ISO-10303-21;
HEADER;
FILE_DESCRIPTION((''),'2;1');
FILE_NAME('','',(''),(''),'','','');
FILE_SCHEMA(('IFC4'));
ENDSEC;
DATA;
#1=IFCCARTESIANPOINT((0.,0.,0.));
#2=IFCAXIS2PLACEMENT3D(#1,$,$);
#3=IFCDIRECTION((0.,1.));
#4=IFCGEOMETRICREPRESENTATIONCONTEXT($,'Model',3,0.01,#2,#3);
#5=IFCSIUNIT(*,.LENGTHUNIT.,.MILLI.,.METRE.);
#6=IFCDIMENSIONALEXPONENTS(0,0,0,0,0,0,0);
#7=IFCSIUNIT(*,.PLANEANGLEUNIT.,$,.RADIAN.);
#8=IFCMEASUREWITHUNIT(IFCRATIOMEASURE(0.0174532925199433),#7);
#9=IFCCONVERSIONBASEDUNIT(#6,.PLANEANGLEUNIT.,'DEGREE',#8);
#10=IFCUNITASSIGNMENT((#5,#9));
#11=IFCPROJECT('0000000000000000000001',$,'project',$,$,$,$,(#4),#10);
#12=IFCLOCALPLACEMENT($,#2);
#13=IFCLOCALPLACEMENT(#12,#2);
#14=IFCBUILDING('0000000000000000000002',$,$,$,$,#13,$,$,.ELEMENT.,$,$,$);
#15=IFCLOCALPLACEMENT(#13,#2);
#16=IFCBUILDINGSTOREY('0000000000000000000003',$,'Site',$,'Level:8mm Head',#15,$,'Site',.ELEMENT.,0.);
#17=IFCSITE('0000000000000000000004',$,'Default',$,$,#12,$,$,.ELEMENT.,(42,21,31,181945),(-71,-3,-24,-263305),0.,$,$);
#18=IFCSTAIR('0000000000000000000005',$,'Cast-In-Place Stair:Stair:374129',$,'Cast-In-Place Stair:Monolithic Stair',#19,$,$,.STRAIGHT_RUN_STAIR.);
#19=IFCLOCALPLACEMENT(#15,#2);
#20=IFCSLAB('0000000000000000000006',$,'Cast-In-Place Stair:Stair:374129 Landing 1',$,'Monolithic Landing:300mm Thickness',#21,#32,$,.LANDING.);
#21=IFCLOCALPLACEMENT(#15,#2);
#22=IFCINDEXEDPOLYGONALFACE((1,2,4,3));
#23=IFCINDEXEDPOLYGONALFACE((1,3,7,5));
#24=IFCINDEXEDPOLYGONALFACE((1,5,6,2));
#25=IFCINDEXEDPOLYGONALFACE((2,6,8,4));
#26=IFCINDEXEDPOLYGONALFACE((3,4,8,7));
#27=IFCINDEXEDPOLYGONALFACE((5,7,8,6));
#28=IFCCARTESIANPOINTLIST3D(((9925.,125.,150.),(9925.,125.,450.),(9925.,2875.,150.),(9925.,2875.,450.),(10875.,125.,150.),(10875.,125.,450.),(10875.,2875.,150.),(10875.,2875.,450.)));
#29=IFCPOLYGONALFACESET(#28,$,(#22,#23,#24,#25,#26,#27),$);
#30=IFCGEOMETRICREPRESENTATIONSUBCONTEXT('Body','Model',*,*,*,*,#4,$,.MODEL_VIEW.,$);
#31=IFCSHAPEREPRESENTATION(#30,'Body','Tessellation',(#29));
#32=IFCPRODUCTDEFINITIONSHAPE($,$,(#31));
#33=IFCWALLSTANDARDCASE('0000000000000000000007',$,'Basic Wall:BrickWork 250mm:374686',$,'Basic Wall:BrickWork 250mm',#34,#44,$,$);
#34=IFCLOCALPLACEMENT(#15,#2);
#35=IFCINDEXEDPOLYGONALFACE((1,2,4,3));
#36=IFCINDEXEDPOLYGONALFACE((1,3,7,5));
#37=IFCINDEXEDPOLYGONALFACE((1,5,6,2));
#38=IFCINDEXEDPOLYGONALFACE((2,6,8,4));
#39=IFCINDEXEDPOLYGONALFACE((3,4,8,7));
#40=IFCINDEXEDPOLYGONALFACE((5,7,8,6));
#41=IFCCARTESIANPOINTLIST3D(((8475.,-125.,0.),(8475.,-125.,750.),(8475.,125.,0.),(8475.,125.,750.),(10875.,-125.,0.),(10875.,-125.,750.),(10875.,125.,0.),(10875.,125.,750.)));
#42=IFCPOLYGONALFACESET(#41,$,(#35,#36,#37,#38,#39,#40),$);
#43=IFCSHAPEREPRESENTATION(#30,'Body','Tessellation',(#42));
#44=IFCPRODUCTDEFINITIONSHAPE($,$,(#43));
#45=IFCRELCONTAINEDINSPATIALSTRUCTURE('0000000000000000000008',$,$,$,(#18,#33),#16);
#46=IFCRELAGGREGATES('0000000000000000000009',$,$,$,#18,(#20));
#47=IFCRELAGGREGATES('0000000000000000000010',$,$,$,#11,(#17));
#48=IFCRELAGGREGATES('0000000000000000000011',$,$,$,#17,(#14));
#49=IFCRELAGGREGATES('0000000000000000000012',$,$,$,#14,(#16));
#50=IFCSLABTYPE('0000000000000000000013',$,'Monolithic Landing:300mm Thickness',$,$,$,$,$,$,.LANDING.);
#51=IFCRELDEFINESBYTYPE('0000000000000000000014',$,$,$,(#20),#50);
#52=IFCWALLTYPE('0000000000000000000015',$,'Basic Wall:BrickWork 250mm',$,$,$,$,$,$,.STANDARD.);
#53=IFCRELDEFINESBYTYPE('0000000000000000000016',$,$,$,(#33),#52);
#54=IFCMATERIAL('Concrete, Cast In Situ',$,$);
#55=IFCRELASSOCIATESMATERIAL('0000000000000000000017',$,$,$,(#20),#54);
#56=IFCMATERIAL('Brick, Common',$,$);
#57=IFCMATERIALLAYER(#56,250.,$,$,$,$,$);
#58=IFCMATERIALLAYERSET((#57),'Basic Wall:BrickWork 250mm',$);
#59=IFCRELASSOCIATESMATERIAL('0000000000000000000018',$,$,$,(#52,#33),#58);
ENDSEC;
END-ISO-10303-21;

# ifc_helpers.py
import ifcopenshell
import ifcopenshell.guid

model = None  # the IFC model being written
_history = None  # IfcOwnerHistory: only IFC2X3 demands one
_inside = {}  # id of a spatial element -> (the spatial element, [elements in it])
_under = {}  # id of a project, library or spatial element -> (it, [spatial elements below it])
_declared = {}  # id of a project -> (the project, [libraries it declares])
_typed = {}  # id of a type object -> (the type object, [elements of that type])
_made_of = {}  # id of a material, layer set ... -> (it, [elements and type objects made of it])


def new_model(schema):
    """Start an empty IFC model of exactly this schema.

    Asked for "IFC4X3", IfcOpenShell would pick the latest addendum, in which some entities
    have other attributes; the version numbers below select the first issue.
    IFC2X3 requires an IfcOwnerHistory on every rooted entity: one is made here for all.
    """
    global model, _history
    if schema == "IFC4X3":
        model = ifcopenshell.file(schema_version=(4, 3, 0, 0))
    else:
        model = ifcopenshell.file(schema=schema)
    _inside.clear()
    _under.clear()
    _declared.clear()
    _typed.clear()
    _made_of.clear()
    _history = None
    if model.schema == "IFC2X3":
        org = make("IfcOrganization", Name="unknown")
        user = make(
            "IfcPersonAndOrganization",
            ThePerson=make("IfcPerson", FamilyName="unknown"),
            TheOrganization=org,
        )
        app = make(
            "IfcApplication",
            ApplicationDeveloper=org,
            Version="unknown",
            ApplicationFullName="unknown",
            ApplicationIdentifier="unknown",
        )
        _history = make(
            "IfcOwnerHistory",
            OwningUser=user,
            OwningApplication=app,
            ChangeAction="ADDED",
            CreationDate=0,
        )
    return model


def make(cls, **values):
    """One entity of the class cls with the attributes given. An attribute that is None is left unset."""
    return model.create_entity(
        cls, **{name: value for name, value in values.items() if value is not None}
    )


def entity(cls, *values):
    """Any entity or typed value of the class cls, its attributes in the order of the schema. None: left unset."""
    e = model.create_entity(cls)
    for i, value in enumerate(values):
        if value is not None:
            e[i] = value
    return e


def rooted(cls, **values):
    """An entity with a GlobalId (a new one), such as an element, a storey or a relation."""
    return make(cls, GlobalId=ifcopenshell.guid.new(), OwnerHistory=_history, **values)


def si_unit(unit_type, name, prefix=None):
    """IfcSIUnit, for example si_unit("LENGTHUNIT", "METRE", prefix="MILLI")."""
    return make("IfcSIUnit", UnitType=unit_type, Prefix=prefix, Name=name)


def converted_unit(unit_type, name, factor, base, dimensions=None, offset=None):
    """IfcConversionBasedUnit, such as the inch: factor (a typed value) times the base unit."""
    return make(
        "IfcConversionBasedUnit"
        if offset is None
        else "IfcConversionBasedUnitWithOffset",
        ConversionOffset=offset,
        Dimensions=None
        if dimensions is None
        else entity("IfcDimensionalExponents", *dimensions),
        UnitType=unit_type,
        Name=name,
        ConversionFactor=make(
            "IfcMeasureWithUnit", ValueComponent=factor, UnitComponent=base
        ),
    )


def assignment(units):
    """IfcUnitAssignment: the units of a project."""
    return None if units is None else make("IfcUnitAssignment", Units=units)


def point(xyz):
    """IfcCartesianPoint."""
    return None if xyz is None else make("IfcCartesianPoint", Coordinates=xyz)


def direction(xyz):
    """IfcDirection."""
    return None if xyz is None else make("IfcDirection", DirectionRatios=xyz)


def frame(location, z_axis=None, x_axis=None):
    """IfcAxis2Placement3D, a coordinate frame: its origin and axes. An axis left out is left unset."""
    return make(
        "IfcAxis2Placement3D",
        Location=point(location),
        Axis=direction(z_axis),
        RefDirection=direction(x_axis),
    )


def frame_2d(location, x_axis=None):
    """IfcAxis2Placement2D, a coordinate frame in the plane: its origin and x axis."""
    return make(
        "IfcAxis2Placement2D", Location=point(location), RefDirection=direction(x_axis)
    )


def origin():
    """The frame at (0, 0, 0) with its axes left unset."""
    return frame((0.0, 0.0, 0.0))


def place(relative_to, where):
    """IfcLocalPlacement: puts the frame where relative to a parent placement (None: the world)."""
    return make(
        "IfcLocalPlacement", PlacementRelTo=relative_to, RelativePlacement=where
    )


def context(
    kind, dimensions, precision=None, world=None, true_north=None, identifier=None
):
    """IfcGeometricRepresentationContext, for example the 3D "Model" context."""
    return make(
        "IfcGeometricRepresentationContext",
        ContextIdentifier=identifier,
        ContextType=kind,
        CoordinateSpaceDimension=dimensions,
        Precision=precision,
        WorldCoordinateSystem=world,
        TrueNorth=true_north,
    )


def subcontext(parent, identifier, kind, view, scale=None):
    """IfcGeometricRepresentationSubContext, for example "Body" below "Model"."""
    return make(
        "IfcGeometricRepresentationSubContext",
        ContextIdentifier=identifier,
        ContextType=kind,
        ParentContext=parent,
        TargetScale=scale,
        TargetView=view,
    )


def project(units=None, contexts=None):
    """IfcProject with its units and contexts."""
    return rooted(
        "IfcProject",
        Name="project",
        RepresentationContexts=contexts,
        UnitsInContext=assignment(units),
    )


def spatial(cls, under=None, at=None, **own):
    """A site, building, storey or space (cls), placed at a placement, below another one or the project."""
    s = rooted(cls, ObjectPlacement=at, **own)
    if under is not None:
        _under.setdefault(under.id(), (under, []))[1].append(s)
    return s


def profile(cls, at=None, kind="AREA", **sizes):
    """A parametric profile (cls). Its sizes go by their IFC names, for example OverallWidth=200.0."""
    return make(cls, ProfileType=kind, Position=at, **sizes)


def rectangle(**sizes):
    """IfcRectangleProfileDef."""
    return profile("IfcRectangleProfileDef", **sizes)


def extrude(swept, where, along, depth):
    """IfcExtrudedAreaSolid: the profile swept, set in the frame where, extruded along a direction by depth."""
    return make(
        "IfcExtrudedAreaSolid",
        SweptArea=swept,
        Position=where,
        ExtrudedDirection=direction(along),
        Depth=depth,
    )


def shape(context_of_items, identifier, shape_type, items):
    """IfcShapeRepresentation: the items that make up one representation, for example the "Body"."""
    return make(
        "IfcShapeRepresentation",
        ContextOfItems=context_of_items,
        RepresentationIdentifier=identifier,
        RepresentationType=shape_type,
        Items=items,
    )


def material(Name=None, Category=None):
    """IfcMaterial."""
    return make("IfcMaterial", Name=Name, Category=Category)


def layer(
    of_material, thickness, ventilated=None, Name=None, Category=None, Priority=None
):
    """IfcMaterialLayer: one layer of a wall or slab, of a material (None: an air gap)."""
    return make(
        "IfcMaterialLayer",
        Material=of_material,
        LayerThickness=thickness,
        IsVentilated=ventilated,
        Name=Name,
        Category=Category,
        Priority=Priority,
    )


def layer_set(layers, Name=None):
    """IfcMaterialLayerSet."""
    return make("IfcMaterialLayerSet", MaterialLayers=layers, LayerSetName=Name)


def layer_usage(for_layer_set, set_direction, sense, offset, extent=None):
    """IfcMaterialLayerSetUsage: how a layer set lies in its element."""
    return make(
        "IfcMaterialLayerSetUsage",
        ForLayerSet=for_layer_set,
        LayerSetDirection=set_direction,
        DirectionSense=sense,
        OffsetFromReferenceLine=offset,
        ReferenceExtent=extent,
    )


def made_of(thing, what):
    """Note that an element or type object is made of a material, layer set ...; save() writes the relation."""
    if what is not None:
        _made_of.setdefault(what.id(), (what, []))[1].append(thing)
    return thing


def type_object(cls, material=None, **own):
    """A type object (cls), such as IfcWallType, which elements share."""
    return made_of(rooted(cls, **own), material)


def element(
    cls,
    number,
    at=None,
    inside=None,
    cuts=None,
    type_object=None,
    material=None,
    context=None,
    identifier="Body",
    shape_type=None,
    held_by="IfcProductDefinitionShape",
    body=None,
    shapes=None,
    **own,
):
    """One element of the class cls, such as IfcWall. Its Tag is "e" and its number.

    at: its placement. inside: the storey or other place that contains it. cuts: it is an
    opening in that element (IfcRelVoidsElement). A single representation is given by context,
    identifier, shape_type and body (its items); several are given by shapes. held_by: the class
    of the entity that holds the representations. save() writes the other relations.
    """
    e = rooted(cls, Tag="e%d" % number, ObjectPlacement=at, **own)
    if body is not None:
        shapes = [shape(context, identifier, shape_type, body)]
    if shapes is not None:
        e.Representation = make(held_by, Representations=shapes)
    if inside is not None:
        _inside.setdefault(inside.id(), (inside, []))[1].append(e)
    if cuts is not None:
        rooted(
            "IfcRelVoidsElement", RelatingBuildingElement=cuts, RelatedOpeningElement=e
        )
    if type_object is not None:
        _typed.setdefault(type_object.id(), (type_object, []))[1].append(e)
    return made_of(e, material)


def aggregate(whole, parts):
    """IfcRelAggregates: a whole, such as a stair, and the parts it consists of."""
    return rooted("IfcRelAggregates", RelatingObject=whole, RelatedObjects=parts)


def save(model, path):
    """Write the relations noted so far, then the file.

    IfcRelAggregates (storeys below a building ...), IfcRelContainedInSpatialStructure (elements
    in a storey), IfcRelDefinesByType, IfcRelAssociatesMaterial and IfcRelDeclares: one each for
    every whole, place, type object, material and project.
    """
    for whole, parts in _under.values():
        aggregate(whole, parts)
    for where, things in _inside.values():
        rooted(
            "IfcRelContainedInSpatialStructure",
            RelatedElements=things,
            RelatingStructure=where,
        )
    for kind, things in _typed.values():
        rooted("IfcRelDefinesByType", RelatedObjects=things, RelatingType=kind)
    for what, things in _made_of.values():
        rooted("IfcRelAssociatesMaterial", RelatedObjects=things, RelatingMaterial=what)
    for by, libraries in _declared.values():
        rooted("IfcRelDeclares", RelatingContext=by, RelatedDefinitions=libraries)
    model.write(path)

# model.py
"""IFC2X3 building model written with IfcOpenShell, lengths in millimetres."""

from ifc_helpers import new_model, entity, si_unit, converted_unit, direction, frame, frame_2d, origin, place, context, subcontext, project, spatial, rectangle, extrude, material, layer, layer_set, layer_usage, type_object, element, aggregate, save


model = new_model("IFC2X3")

# Units and contexts
model_context = context("Model", 3, precision=0.01, world=origin(), true_north=direction((0.0, 1.0)))
body_context = subcontext(model_context, "Body", "Model", "MODEL_VIEW")
ifc_project = project(units=[si_unit("LENGTHUNIT", "METRE", prefix="MILLI"), converted_unit("PLANEANGLEUNIT", "DEGREE", entity("IfcRatioMeasure", 0.0174532925199433), si_unit("PLANEANGLEUNIT", "RADIAN"), dimensions=[0, 0, 0, 0, 0, 0, 0])], contexts=[model_context])

# Site, building, storey
site_placement = place(None, origin())
site = spatial("IfcSite", under=ifc_project, at=site_placement, Name="Default", CompositionType="ELEMENT", RefLatitude=(42, 21, 31, 181945), RefLongitude=(-71, -3, -24, -263305), RefElevation=0.0)
building_placement = place(site_placement, origin())
building = spatial("IfcBuilding", under=site, at=building_placement, CompositionType="ELEMENT")
storey_placement = place(building_placement, origin())
storey = spatial("IfcBuildingStorey", under=building, at=storey_placement, Name="Site", ObjectType="Level:8mm Head", LongName="Site", CompositionType="ELEMENT", Elevation=0.0)

# Stair, slab
stair_placement = place(storey_placement, origin())
stair = element("IfcStair", 1, at=stair_placement, inside=storey, Name="Cast-In-Place Stair:Stair:374129", ObjectType="Cast-In-Place Stair:Monolithic Stair", ShapeType="STRAIGHT_RUN_STAIR")
ifc_material_1 = material(Name="Concrete, Cast In Situ")
slab_type = type_object("IfcSlabType", Name="Monolithic Landing:300mm Thickness", PredefinedType="LANDING")
slab_placement = place(stair_placement, origin())
slab = element("IfcSlab", 2, at=slab_placement, type_object=slab_type, material=ifc_material_1, Name="Cast-In-Place Stair:Stair:374129 Landing 1", ObjectType="Monolithic Landing:300mm Thickness", PredefinedType="LANDING", context=body_context, shape_type="SweptSolid", body=[
    extrude(rectangle(XDim=950.0, YDim=2750.0, at=frame_2d((0.0, 0.0), x_axis=(1.0, 0.0))), frame((10400.0, 1500.0, 150.0)), (0.0, 0.0, 1.0), 300.0),
])
aggregate(stair, [slab])

# Wall
ifc_material_2 = material(Name="Brick, Common")
ifc_layer = layer(ifc_material_2, 250.0)
ifc_layer_set = layer_set([ifc_layer], Name="Basic Wall:BrickWork 250mm")
ifc_layer_usage = layer_usage(ifc_layer_set, "AXIS2", "NEGATIVE", 125.0)
wall_type = type_object("IfcWallType", Name="Basic Wall:BrickWork 250mm", PredefinedType="STANDARD", material=ifc_layer_set)
wall_placement = place(storey_placement, frame((8475.0, 0.0, 0.0)))
element("IfcWallStandardCase", 3, at=wall_placement, inside=storey, type_object=wall_type, material=ifc_layer_usage, Name="Basic Wall:BrickWork 250mm:374686", ObjectType="Basic Wall:BrickWork 250mm", context=body_context, shape_type="SweptSolid", body=[
    extrude(rectangle(XDim=2400.0, YDim=250.0, at=frame_2d((1200.0, 0.0), x_axis=(-1.0, 0.0))), origin(), (0.0, 0.0, 1.0), 750.0),
])

save(model, "model.ifc")
